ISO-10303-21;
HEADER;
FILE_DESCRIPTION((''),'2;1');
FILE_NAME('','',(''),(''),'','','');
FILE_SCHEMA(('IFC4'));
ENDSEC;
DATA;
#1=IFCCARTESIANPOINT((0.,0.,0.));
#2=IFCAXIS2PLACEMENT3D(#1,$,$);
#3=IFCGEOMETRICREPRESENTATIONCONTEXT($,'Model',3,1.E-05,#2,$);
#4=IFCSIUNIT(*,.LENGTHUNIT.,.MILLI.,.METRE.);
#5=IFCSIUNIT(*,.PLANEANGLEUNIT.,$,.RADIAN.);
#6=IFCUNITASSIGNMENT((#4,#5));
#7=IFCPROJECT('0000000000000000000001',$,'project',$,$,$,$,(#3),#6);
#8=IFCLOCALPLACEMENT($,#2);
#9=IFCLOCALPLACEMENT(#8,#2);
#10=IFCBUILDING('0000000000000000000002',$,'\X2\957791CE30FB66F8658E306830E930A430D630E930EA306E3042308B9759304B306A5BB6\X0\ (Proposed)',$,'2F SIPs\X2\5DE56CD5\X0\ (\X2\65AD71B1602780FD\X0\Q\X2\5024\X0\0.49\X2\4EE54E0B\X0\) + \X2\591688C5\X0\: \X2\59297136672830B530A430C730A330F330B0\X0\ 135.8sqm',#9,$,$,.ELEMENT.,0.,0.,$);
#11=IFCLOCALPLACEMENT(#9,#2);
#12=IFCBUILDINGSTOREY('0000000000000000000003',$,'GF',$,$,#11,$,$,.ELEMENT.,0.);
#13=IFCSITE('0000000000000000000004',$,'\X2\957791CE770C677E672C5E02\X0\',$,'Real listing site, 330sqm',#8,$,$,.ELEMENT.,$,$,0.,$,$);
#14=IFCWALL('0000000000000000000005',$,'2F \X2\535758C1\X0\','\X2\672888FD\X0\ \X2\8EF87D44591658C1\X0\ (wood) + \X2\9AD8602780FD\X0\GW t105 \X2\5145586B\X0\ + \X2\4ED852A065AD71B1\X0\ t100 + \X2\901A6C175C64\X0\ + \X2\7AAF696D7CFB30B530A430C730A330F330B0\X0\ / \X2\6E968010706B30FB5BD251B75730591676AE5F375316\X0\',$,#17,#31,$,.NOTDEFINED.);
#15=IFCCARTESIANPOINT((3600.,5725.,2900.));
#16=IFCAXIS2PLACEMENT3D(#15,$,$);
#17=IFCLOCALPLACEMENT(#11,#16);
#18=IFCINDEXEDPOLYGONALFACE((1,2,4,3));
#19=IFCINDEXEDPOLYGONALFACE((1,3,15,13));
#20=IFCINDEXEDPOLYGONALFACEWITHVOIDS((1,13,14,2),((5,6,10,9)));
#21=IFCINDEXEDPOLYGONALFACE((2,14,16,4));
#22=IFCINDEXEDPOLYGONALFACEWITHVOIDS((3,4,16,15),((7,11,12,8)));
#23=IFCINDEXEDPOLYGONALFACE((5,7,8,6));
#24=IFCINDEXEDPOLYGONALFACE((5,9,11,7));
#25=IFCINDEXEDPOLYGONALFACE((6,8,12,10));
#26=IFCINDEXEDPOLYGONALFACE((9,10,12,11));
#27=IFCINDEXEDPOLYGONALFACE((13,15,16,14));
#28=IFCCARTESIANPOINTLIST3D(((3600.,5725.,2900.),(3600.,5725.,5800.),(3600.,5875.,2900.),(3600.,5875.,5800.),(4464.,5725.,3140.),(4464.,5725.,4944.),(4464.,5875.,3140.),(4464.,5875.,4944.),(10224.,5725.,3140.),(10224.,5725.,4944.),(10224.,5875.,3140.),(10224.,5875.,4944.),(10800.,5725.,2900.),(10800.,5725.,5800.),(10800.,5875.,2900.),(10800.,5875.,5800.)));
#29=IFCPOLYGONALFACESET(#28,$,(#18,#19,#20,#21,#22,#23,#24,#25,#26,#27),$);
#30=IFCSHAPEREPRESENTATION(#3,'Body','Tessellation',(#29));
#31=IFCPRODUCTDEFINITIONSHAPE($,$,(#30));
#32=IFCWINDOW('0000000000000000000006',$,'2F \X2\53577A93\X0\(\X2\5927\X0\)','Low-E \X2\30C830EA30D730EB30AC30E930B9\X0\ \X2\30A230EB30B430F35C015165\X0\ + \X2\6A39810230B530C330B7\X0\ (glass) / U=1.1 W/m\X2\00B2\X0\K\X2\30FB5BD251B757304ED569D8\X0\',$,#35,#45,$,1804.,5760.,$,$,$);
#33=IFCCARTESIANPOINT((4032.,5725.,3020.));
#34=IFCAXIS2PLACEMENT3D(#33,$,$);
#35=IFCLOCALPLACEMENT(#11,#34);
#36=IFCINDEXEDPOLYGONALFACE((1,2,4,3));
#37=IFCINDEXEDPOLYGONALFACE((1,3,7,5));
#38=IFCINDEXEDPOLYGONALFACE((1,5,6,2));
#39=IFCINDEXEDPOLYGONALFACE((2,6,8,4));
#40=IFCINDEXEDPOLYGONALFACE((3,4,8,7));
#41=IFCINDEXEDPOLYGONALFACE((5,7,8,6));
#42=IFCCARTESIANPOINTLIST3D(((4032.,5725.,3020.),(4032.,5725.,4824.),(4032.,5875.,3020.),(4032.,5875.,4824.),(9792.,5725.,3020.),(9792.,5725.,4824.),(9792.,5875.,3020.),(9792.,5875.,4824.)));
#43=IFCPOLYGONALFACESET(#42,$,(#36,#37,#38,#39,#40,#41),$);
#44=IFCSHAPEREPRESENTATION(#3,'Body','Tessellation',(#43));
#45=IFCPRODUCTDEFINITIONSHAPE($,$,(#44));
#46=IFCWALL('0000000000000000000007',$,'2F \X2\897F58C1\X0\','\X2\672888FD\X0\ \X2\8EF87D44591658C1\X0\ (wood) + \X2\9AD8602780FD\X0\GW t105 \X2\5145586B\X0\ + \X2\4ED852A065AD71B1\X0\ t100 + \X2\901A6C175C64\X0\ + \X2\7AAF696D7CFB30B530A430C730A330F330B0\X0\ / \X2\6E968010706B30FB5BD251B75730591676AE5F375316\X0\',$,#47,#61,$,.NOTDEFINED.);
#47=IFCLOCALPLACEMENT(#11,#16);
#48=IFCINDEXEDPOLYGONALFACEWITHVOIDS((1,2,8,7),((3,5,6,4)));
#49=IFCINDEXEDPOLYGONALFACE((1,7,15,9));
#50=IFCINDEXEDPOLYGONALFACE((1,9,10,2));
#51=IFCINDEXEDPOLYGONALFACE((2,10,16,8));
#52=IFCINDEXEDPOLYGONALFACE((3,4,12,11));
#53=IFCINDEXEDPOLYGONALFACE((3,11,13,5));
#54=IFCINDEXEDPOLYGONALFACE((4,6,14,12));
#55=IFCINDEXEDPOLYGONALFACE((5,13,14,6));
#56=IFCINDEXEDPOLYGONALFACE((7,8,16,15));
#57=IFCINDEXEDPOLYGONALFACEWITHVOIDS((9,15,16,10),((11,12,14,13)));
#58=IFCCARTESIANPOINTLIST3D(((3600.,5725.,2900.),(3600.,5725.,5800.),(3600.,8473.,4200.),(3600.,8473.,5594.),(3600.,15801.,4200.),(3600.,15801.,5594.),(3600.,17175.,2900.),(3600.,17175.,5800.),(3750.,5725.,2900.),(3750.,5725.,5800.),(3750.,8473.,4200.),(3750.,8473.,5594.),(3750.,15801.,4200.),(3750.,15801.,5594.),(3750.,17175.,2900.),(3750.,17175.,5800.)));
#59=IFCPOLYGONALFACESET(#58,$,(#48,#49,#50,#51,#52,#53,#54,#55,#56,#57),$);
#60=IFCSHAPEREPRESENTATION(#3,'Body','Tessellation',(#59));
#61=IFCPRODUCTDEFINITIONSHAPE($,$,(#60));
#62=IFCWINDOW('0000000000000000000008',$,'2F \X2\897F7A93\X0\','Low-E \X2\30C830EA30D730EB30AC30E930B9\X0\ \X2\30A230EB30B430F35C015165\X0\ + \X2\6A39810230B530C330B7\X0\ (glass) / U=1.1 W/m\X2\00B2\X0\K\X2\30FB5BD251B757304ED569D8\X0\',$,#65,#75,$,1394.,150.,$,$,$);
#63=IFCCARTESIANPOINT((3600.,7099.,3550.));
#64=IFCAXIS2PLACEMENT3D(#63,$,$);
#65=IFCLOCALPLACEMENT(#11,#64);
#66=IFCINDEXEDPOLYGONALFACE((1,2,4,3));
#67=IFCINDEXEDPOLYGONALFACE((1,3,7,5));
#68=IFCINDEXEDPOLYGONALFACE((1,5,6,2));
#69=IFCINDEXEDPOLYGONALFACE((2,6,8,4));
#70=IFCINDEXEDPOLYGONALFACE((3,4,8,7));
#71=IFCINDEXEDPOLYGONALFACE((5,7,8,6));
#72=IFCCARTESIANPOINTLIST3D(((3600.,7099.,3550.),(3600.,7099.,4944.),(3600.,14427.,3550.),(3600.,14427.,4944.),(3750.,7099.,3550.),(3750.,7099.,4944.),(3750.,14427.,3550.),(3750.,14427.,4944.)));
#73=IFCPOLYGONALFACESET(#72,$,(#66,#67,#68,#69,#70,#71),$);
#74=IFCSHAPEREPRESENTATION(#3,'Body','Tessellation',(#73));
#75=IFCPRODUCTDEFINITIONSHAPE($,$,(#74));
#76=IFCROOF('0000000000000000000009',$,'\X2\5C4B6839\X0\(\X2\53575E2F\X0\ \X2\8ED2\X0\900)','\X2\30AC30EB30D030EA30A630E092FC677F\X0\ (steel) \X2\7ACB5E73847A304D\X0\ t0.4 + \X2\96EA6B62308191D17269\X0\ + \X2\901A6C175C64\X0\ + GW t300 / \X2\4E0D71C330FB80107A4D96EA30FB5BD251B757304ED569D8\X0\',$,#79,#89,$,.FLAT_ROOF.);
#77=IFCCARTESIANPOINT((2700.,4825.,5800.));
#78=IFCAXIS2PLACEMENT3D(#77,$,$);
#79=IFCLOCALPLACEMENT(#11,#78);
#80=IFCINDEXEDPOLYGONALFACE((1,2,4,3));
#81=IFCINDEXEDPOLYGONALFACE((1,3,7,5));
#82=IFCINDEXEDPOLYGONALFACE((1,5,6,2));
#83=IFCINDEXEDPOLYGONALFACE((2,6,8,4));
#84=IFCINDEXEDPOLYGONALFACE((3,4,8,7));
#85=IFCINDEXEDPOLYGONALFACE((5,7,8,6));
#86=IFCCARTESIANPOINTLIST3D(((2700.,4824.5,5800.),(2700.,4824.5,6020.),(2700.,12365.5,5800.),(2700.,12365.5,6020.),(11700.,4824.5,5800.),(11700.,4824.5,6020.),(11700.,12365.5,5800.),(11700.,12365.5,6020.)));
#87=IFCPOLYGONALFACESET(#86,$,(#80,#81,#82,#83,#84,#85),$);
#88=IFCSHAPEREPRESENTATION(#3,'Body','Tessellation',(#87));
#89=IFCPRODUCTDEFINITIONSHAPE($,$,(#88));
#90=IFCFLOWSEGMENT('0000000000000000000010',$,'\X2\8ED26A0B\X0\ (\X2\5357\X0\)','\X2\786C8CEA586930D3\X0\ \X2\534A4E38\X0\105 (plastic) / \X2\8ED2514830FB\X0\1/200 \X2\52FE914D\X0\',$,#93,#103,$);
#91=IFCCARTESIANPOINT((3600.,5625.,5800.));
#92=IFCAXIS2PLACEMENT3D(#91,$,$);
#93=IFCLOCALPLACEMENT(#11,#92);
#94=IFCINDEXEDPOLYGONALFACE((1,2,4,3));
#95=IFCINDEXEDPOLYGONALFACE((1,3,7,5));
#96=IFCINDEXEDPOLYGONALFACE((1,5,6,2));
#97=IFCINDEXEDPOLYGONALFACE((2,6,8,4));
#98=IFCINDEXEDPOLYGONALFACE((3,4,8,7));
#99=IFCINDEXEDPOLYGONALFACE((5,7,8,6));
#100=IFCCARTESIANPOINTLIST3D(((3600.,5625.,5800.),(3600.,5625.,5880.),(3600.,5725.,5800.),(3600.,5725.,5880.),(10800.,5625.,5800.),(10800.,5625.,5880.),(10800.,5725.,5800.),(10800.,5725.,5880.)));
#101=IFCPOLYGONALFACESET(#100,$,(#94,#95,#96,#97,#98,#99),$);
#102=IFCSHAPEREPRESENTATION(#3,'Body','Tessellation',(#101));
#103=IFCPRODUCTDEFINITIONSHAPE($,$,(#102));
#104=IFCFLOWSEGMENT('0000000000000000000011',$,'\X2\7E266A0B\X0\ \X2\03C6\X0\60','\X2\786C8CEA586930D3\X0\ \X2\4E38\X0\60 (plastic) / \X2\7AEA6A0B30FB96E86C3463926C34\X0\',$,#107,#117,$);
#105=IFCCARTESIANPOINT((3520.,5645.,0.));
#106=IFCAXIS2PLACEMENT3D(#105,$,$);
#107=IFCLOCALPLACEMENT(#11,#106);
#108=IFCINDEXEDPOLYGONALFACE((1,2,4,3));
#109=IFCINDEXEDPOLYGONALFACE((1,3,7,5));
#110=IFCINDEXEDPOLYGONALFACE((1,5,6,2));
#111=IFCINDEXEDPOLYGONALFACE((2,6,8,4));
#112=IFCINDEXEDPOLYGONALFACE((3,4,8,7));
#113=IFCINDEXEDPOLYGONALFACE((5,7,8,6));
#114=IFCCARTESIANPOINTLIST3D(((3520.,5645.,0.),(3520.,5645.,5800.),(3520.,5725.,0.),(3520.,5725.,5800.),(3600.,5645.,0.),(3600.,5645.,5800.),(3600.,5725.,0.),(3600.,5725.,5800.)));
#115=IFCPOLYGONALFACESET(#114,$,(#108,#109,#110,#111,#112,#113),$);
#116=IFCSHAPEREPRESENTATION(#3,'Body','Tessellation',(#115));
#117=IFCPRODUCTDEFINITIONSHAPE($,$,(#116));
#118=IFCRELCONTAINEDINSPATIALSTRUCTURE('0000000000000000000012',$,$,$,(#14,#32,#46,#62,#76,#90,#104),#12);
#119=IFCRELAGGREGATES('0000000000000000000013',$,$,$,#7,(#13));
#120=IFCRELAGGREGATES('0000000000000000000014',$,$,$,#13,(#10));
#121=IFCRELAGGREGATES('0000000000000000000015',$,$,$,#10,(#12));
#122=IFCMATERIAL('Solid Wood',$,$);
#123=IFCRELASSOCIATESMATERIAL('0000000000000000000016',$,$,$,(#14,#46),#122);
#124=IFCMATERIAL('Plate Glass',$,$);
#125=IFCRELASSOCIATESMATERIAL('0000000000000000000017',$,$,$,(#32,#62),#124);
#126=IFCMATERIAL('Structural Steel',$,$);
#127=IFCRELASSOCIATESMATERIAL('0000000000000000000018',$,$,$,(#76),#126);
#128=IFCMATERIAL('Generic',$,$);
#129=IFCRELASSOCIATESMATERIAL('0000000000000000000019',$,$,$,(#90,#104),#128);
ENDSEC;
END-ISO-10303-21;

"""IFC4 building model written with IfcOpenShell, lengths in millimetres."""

from ifc_helpers import new_model, si_unit, frame, frame_2d, origin, place, context, project, spatial, rectangle, extrude, material, element, fill, save


model = new_model("IFC4")

# Units and contexts
model_context = context("Model", 3, precision=1e-05, world=origin())
ifc_project = project(units=[si_unit("LENGTHUNIT", "METRE", prefix="MILLI"), si_unit("PLANEANGLEUNIT", "RADIAN")], contexts=[model_context])

# Site, building, storey
site_placement = place(None, origin())
site = spatial("IfcSite", under=ifc_project, at=site_placement, Name="長野県松本市", ObjectType="Real listing site, 330sqm", CompositionType="ELEMENT", RefElevation=0.0)
building_placement = place(site_placement, origin())
building = spatial("IfcBuilding", under=site, at=building_placement, Name="長野・書斎とライブラリのある静かな家 (Proposed)", ObjectType="2F SIPs工法 (断熱性能Q値0.49以下) + 外装: 天然木サイディング 135.8sqm", CompositionType="ELEMENT", ElevationOfRefHeight=0.0, ElevationOfTerrain=0.0)
storey_placement = place(building_placement, origin())
storey = spatial("IfcBuildingStorey", under=building, at=storey_placement, Name="GF", CompositionType="ELEMENT", Elevation=0.0)

# Shared definitions
ifc_material_1 = material(Name="Solid Wood")

# Shared definitions
ifc_material_2 = material(Name="Plate Glass")

# Walls, openings, windows
wall_1_placement = place(storey_placement, frame((3600.0, 5725.0, 2900.0)))
wall_1 = element("IfcWall", 1, at=wall_1_placement, inside=storey, material=ifc_material_1, Name="2F 南壁", Description="木製 軸組外壁 (wood) + 高性能GW t105 充填 + 付加断熱 t100 + 通気層 + 窯業系サイディング / 準耐火・寒冷地外皮強化", PredefinedType="NOTDEFINED", context=model_context, shape_type="SweptSolid", body=[
    extrude(rectangle(XDim=7200.0, YDim=150.0, at=frame_2d((3600.0, 75.0))), frame((3600.0, 5725.0, 2900.0)), (0.0, 0.0, 1.0), 2900.0),
])
opening_1_placement = place(storey_placement, frame((4032.0, 5725.0, 3020.0)))
opening_1 = element("IfcOpeningElement", 2, at=opening_1_placement, cuts=wall_1, PredefinedType="NOTDEFINED", context=model_context, shape_type="SweptSolid", body=[
    extrude(rectangle(XDim=5760.0, YDim=150.0, at=frame_2d((2880.0, 75.0))), frame((4032.0, 5725.0, 3020.0)), (0.0, 0.0, 1.0), 1804.0),
])
window_1_placement = place(storey_placement, frame((4032.0, 5725.0, 3020.0)))
window_1 = element("IfcWindow", 3, at=window_1_placement, inside=storey, material=ifc_material_2, Name="2F 南窓(大)", Description="Low-E トリプルガラス アルゴン封入 + 樹脂サッシ (glass) / U=1.1 W/m²K・寒冷地仕様", OverallHeight=1804.0, OverallWidth=5760.0, context=model_context, shape_type="SweptSolid", body=[
    extrude(rectangle(XDim=5760.0, YDim=150.0, at=frame_2d((2880.0, 75.0))), frame((4032.0, 5725.0, 3020.0)), (0.0, 0.0, 1.0), 1804.0),
])
fill(opening_1, window_1)
wall_2_placement = place(storey_placement, frame((3600.0, 5725.0, 2900.0)))
wall_2 = element("IfcWall", 4, at=wall_2_placement, inside=storey, material=ifc_material_1, Name="2F 西壁", Description="木製 軸組外壁 (wood) + 高性能GW t105 充填 + 付加断熱 t100 + 通気層 + 窯業系サイディング / 準耐火・寒冷地外皮強化", PredefinedType="NOTDEFINED", context=model_context, shape_type="SweptSolid", body=[
    extrude(rectangle(XDim=150.0, YDim=11450.0, at=frame_2d((75.0, 5725.0))), frame((3600.0, 5725.0, 2900.0)), (0.0, 0.0, 1.0), 2900.0),
])
opening_2_placement = place(storey_placement, frame((3600.0, 7099.0, 3550.0)))
opening_2 = element("IfcOpeningElement", 5, at=opening_2_placement, cuts=wall_2, PredefinedType="NOTDEFINED", context=model_context, shape_type="SweptSolid", body=[
    extrude(rectangle(XDim=150.0, YDim=7328.0, at=frame_2d((75.0, 3664.0))), frame((3600.0, 7099.0, 3550.0)), (0.0, 0.0, 1.0), 1394.0),
])
window_2_placement = place(storey_placement, frame((3600.0, 7099.0, 3550.0)))
window_2 = element("IfcWindow", 6, at=window_2_placement, inside=storey, material=ifc_material_2, Name="2F 西窓", Description="Low-E トリプルガラス アルゴン封入 + 樹脂サッシ (glass) / U=1.1 W/m²K・寒冷地仕様", OverallHeight=1394.0, OverallWidth=150.0, context=model_context, shape_type="SweptSolid", body=[
    extrude(rectangle(XDim=150.0, YDim=7328.0, at=frame_2d((75.0, 3664.0))), frame((3600.0, 7099.0, 3550.0)), (0.0, 0.0, 1.0), 1394.0),
])
fill(opening_2, window_2)

# Roof
ifc_material_3 = material(Name="Structural Steel")
for number, where, name in (
    (7, (2700.0, 4825.0, 5800.0), "屋根(南帯 軒900)"),
):
    element("IfcRoof", number, at=place(storey_placement, frame(where)), inside=storey, material=ifc_material_3, Name=name, Description="ガルバリウム鋼板 (steel) 立平葺き t0.4 + 雪止め金物 + 通気層 + GW t300 / 不燃・耐積雪・寒冷地仕様", PredefinedType="FLAT_ROOF", context=model_context, shape_type="SweptSolid", body=[
        extrude(rectangle(XDim=9000.0, YDim=7541.0, at=frame_2d((4500.0, 3770.0))), frame((2700.0, 4825.0, 5800.0)), (0.0, 0.0, 1.0), 220.0),
    ])

# Flow segments
ifc_material_4 = material(Name="Generic")
flow_segment_1_placement = place(storey_placement, frame((3600.0, 5625.0, 5800.0)))
element("IfcFlowSegment", 8, at=flow_segment_1_placement, inside=storey, material=ifc_material_4, Name="軒樋 (南)", Description="硬質塩ビ 半丸105 (plastic) / 軒先・1/200 勾配", context=model_context, shape_type="SweptSolid", body=[
    extrude(rectangle(XDim=7200.0, YDim=100.0, at=frame_2d((3600.0, 50.0))), frame((3600.0, 5625.0, 5800.0)), (0.0, 0.0, 1.0), 80.0),
])
flow_segment_2_placement = place(storey_placement, frame((3520.0, 5645.0, 0.0)))
element("IfcFlowSegment", 9, at=flow_segment_2_placement, inside=storey, material=ifc_material_4, Name="縦樋 φ60", Description="硬質塩ビ 丸60 (plastic) / 竪樋・雨水排水", context=model_context, shape_type="SweptSolid", body=[
    extrude(rectangle(XDim=80.0, YDim=80.0, at=frame_2d((40.0, 40.0))), frame((3520.0, 5645.0, 0.0)), (0.0, 0.0, 1.0), 5800.0),
])

save(model, "model.ifc")
